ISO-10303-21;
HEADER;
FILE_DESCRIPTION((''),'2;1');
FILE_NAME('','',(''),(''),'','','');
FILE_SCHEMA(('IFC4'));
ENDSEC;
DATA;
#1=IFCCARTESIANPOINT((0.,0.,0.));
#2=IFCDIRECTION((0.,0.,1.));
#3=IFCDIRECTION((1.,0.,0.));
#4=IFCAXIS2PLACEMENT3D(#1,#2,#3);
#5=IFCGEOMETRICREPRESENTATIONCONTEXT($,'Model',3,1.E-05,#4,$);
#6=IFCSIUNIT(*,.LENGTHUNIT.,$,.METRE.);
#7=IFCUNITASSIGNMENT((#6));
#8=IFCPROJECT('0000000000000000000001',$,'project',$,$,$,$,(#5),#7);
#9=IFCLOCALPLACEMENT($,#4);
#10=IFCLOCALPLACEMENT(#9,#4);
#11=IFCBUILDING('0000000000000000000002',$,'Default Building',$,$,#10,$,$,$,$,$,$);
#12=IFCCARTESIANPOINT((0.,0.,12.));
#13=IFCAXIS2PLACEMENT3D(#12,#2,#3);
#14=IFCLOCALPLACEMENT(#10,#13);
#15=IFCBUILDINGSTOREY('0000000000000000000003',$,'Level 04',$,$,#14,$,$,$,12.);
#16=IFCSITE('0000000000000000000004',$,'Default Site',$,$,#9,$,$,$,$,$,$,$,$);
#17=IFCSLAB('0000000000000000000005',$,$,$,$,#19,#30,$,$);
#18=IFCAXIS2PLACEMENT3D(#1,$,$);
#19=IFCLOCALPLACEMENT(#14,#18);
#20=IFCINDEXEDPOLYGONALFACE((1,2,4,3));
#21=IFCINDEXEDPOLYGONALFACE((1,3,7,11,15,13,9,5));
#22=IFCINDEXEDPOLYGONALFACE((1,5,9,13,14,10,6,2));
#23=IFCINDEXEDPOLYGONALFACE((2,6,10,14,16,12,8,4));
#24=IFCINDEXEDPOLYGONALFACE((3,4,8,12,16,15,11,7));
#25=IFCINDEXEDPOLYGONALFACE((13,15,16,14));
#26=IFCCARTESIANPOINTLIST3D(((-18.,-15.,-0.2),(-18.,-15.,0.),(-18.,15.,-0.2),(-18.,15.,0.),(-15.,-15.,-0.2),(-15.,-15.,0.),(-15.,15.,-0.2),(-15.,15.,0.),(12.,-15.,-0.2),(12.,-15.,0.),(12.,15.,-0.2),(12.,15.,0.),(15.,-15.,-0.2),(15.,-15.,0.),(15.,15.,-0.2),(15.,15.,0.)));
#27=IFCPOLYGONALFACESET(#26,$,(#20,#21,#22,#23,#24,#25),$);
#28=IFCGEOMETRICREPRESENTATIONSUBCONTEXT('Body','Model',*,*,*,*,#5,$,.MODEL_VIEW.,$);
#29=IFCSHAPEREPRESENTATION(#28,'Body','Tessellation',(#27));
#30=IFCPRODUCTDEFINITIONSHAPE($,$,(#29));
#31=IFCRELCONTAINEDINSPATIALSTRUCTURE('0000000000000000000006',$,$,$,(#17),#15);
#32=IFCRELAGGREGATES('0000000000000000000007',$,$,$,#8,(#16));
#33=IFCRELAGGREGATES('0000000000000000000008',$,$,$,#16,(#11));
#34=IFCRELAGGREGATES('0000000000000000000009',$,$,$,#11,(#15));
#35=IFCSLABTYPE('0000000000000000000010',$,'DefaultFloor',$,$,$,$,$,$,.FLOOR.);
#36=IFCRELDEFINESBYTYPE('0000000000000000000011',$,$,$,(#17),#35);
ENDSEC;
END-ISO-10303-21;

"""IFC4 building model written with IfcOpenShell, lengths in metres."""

from ifc_helpers import new_model, si_unit, frame, origin_with_axes, place, context, subcontext, project, spatial, polyline, outline, extrude, type_object, element, save


model = new_model("IFC4")

# Units and contexts
model_context = context("Model", 3, precision=1e-05, world=origin_with_axes())
body_context = subcontext(model_context, "Body", "Model", "MODEL_VIEW")
ifc_project = project(units=[si_unit("LENGTHUNIT", "METRE")], contexts=[model_context])

# Site, building, storey
site_placement = place(None, origin_with_axes())
site = spatial("IfcSite", under=ifc_project, at=site_placement, Name="Default Site")
building_placement = place(site_placement, origin_with_axes())
building = spatial("IfcBuilding", under=site, at=building_placement, Name="Default Building")
storey_placement = place(building_placement, frame((0.0, 0.0, 12.0), z_axis=(0.0, 0.0, 1.0), x_axis=(1.0, 0.0, 0.0)))
storey = spatial("IfcBuildingStorey", under=building, at=storey_placement, Name="Level 04", Elevation=12.0)

# Slab
slab_type = type_object("IfcSlabType", Name="DefaultFloor", PredefinedType="FLOOR")
slab_placement = place(storey_placement, frame((0.0, 0.0, -12.0), z_axis=(0.0, 0.0, 1.0), x_axis=(1.0, 0.0, 0.0)))
element("IfcSlab", 1, at=slab_placement, inside=storey, type_object=slab_type, context=body_context, shape_type="SweptSolid", body=[
    extrude(outline(polyline([(-18.0, -15.0), (-18.0, 15.0), (-15.0, 15.0), (12.0, 15.0), (15.0, 15.0), (15.0, -15.0), (12.0, -15.0), (-15.0, -15.0), (-18.0, -15.0)])), frame((0.0, 0.0, 12.0), z_axis=(0.0, 0.0, 1.0), x_axis=(1.0, 0.0, 0.0)), (0.0, 0.0, -1.0), 0.2),
])

save(model, "model.ifc")
